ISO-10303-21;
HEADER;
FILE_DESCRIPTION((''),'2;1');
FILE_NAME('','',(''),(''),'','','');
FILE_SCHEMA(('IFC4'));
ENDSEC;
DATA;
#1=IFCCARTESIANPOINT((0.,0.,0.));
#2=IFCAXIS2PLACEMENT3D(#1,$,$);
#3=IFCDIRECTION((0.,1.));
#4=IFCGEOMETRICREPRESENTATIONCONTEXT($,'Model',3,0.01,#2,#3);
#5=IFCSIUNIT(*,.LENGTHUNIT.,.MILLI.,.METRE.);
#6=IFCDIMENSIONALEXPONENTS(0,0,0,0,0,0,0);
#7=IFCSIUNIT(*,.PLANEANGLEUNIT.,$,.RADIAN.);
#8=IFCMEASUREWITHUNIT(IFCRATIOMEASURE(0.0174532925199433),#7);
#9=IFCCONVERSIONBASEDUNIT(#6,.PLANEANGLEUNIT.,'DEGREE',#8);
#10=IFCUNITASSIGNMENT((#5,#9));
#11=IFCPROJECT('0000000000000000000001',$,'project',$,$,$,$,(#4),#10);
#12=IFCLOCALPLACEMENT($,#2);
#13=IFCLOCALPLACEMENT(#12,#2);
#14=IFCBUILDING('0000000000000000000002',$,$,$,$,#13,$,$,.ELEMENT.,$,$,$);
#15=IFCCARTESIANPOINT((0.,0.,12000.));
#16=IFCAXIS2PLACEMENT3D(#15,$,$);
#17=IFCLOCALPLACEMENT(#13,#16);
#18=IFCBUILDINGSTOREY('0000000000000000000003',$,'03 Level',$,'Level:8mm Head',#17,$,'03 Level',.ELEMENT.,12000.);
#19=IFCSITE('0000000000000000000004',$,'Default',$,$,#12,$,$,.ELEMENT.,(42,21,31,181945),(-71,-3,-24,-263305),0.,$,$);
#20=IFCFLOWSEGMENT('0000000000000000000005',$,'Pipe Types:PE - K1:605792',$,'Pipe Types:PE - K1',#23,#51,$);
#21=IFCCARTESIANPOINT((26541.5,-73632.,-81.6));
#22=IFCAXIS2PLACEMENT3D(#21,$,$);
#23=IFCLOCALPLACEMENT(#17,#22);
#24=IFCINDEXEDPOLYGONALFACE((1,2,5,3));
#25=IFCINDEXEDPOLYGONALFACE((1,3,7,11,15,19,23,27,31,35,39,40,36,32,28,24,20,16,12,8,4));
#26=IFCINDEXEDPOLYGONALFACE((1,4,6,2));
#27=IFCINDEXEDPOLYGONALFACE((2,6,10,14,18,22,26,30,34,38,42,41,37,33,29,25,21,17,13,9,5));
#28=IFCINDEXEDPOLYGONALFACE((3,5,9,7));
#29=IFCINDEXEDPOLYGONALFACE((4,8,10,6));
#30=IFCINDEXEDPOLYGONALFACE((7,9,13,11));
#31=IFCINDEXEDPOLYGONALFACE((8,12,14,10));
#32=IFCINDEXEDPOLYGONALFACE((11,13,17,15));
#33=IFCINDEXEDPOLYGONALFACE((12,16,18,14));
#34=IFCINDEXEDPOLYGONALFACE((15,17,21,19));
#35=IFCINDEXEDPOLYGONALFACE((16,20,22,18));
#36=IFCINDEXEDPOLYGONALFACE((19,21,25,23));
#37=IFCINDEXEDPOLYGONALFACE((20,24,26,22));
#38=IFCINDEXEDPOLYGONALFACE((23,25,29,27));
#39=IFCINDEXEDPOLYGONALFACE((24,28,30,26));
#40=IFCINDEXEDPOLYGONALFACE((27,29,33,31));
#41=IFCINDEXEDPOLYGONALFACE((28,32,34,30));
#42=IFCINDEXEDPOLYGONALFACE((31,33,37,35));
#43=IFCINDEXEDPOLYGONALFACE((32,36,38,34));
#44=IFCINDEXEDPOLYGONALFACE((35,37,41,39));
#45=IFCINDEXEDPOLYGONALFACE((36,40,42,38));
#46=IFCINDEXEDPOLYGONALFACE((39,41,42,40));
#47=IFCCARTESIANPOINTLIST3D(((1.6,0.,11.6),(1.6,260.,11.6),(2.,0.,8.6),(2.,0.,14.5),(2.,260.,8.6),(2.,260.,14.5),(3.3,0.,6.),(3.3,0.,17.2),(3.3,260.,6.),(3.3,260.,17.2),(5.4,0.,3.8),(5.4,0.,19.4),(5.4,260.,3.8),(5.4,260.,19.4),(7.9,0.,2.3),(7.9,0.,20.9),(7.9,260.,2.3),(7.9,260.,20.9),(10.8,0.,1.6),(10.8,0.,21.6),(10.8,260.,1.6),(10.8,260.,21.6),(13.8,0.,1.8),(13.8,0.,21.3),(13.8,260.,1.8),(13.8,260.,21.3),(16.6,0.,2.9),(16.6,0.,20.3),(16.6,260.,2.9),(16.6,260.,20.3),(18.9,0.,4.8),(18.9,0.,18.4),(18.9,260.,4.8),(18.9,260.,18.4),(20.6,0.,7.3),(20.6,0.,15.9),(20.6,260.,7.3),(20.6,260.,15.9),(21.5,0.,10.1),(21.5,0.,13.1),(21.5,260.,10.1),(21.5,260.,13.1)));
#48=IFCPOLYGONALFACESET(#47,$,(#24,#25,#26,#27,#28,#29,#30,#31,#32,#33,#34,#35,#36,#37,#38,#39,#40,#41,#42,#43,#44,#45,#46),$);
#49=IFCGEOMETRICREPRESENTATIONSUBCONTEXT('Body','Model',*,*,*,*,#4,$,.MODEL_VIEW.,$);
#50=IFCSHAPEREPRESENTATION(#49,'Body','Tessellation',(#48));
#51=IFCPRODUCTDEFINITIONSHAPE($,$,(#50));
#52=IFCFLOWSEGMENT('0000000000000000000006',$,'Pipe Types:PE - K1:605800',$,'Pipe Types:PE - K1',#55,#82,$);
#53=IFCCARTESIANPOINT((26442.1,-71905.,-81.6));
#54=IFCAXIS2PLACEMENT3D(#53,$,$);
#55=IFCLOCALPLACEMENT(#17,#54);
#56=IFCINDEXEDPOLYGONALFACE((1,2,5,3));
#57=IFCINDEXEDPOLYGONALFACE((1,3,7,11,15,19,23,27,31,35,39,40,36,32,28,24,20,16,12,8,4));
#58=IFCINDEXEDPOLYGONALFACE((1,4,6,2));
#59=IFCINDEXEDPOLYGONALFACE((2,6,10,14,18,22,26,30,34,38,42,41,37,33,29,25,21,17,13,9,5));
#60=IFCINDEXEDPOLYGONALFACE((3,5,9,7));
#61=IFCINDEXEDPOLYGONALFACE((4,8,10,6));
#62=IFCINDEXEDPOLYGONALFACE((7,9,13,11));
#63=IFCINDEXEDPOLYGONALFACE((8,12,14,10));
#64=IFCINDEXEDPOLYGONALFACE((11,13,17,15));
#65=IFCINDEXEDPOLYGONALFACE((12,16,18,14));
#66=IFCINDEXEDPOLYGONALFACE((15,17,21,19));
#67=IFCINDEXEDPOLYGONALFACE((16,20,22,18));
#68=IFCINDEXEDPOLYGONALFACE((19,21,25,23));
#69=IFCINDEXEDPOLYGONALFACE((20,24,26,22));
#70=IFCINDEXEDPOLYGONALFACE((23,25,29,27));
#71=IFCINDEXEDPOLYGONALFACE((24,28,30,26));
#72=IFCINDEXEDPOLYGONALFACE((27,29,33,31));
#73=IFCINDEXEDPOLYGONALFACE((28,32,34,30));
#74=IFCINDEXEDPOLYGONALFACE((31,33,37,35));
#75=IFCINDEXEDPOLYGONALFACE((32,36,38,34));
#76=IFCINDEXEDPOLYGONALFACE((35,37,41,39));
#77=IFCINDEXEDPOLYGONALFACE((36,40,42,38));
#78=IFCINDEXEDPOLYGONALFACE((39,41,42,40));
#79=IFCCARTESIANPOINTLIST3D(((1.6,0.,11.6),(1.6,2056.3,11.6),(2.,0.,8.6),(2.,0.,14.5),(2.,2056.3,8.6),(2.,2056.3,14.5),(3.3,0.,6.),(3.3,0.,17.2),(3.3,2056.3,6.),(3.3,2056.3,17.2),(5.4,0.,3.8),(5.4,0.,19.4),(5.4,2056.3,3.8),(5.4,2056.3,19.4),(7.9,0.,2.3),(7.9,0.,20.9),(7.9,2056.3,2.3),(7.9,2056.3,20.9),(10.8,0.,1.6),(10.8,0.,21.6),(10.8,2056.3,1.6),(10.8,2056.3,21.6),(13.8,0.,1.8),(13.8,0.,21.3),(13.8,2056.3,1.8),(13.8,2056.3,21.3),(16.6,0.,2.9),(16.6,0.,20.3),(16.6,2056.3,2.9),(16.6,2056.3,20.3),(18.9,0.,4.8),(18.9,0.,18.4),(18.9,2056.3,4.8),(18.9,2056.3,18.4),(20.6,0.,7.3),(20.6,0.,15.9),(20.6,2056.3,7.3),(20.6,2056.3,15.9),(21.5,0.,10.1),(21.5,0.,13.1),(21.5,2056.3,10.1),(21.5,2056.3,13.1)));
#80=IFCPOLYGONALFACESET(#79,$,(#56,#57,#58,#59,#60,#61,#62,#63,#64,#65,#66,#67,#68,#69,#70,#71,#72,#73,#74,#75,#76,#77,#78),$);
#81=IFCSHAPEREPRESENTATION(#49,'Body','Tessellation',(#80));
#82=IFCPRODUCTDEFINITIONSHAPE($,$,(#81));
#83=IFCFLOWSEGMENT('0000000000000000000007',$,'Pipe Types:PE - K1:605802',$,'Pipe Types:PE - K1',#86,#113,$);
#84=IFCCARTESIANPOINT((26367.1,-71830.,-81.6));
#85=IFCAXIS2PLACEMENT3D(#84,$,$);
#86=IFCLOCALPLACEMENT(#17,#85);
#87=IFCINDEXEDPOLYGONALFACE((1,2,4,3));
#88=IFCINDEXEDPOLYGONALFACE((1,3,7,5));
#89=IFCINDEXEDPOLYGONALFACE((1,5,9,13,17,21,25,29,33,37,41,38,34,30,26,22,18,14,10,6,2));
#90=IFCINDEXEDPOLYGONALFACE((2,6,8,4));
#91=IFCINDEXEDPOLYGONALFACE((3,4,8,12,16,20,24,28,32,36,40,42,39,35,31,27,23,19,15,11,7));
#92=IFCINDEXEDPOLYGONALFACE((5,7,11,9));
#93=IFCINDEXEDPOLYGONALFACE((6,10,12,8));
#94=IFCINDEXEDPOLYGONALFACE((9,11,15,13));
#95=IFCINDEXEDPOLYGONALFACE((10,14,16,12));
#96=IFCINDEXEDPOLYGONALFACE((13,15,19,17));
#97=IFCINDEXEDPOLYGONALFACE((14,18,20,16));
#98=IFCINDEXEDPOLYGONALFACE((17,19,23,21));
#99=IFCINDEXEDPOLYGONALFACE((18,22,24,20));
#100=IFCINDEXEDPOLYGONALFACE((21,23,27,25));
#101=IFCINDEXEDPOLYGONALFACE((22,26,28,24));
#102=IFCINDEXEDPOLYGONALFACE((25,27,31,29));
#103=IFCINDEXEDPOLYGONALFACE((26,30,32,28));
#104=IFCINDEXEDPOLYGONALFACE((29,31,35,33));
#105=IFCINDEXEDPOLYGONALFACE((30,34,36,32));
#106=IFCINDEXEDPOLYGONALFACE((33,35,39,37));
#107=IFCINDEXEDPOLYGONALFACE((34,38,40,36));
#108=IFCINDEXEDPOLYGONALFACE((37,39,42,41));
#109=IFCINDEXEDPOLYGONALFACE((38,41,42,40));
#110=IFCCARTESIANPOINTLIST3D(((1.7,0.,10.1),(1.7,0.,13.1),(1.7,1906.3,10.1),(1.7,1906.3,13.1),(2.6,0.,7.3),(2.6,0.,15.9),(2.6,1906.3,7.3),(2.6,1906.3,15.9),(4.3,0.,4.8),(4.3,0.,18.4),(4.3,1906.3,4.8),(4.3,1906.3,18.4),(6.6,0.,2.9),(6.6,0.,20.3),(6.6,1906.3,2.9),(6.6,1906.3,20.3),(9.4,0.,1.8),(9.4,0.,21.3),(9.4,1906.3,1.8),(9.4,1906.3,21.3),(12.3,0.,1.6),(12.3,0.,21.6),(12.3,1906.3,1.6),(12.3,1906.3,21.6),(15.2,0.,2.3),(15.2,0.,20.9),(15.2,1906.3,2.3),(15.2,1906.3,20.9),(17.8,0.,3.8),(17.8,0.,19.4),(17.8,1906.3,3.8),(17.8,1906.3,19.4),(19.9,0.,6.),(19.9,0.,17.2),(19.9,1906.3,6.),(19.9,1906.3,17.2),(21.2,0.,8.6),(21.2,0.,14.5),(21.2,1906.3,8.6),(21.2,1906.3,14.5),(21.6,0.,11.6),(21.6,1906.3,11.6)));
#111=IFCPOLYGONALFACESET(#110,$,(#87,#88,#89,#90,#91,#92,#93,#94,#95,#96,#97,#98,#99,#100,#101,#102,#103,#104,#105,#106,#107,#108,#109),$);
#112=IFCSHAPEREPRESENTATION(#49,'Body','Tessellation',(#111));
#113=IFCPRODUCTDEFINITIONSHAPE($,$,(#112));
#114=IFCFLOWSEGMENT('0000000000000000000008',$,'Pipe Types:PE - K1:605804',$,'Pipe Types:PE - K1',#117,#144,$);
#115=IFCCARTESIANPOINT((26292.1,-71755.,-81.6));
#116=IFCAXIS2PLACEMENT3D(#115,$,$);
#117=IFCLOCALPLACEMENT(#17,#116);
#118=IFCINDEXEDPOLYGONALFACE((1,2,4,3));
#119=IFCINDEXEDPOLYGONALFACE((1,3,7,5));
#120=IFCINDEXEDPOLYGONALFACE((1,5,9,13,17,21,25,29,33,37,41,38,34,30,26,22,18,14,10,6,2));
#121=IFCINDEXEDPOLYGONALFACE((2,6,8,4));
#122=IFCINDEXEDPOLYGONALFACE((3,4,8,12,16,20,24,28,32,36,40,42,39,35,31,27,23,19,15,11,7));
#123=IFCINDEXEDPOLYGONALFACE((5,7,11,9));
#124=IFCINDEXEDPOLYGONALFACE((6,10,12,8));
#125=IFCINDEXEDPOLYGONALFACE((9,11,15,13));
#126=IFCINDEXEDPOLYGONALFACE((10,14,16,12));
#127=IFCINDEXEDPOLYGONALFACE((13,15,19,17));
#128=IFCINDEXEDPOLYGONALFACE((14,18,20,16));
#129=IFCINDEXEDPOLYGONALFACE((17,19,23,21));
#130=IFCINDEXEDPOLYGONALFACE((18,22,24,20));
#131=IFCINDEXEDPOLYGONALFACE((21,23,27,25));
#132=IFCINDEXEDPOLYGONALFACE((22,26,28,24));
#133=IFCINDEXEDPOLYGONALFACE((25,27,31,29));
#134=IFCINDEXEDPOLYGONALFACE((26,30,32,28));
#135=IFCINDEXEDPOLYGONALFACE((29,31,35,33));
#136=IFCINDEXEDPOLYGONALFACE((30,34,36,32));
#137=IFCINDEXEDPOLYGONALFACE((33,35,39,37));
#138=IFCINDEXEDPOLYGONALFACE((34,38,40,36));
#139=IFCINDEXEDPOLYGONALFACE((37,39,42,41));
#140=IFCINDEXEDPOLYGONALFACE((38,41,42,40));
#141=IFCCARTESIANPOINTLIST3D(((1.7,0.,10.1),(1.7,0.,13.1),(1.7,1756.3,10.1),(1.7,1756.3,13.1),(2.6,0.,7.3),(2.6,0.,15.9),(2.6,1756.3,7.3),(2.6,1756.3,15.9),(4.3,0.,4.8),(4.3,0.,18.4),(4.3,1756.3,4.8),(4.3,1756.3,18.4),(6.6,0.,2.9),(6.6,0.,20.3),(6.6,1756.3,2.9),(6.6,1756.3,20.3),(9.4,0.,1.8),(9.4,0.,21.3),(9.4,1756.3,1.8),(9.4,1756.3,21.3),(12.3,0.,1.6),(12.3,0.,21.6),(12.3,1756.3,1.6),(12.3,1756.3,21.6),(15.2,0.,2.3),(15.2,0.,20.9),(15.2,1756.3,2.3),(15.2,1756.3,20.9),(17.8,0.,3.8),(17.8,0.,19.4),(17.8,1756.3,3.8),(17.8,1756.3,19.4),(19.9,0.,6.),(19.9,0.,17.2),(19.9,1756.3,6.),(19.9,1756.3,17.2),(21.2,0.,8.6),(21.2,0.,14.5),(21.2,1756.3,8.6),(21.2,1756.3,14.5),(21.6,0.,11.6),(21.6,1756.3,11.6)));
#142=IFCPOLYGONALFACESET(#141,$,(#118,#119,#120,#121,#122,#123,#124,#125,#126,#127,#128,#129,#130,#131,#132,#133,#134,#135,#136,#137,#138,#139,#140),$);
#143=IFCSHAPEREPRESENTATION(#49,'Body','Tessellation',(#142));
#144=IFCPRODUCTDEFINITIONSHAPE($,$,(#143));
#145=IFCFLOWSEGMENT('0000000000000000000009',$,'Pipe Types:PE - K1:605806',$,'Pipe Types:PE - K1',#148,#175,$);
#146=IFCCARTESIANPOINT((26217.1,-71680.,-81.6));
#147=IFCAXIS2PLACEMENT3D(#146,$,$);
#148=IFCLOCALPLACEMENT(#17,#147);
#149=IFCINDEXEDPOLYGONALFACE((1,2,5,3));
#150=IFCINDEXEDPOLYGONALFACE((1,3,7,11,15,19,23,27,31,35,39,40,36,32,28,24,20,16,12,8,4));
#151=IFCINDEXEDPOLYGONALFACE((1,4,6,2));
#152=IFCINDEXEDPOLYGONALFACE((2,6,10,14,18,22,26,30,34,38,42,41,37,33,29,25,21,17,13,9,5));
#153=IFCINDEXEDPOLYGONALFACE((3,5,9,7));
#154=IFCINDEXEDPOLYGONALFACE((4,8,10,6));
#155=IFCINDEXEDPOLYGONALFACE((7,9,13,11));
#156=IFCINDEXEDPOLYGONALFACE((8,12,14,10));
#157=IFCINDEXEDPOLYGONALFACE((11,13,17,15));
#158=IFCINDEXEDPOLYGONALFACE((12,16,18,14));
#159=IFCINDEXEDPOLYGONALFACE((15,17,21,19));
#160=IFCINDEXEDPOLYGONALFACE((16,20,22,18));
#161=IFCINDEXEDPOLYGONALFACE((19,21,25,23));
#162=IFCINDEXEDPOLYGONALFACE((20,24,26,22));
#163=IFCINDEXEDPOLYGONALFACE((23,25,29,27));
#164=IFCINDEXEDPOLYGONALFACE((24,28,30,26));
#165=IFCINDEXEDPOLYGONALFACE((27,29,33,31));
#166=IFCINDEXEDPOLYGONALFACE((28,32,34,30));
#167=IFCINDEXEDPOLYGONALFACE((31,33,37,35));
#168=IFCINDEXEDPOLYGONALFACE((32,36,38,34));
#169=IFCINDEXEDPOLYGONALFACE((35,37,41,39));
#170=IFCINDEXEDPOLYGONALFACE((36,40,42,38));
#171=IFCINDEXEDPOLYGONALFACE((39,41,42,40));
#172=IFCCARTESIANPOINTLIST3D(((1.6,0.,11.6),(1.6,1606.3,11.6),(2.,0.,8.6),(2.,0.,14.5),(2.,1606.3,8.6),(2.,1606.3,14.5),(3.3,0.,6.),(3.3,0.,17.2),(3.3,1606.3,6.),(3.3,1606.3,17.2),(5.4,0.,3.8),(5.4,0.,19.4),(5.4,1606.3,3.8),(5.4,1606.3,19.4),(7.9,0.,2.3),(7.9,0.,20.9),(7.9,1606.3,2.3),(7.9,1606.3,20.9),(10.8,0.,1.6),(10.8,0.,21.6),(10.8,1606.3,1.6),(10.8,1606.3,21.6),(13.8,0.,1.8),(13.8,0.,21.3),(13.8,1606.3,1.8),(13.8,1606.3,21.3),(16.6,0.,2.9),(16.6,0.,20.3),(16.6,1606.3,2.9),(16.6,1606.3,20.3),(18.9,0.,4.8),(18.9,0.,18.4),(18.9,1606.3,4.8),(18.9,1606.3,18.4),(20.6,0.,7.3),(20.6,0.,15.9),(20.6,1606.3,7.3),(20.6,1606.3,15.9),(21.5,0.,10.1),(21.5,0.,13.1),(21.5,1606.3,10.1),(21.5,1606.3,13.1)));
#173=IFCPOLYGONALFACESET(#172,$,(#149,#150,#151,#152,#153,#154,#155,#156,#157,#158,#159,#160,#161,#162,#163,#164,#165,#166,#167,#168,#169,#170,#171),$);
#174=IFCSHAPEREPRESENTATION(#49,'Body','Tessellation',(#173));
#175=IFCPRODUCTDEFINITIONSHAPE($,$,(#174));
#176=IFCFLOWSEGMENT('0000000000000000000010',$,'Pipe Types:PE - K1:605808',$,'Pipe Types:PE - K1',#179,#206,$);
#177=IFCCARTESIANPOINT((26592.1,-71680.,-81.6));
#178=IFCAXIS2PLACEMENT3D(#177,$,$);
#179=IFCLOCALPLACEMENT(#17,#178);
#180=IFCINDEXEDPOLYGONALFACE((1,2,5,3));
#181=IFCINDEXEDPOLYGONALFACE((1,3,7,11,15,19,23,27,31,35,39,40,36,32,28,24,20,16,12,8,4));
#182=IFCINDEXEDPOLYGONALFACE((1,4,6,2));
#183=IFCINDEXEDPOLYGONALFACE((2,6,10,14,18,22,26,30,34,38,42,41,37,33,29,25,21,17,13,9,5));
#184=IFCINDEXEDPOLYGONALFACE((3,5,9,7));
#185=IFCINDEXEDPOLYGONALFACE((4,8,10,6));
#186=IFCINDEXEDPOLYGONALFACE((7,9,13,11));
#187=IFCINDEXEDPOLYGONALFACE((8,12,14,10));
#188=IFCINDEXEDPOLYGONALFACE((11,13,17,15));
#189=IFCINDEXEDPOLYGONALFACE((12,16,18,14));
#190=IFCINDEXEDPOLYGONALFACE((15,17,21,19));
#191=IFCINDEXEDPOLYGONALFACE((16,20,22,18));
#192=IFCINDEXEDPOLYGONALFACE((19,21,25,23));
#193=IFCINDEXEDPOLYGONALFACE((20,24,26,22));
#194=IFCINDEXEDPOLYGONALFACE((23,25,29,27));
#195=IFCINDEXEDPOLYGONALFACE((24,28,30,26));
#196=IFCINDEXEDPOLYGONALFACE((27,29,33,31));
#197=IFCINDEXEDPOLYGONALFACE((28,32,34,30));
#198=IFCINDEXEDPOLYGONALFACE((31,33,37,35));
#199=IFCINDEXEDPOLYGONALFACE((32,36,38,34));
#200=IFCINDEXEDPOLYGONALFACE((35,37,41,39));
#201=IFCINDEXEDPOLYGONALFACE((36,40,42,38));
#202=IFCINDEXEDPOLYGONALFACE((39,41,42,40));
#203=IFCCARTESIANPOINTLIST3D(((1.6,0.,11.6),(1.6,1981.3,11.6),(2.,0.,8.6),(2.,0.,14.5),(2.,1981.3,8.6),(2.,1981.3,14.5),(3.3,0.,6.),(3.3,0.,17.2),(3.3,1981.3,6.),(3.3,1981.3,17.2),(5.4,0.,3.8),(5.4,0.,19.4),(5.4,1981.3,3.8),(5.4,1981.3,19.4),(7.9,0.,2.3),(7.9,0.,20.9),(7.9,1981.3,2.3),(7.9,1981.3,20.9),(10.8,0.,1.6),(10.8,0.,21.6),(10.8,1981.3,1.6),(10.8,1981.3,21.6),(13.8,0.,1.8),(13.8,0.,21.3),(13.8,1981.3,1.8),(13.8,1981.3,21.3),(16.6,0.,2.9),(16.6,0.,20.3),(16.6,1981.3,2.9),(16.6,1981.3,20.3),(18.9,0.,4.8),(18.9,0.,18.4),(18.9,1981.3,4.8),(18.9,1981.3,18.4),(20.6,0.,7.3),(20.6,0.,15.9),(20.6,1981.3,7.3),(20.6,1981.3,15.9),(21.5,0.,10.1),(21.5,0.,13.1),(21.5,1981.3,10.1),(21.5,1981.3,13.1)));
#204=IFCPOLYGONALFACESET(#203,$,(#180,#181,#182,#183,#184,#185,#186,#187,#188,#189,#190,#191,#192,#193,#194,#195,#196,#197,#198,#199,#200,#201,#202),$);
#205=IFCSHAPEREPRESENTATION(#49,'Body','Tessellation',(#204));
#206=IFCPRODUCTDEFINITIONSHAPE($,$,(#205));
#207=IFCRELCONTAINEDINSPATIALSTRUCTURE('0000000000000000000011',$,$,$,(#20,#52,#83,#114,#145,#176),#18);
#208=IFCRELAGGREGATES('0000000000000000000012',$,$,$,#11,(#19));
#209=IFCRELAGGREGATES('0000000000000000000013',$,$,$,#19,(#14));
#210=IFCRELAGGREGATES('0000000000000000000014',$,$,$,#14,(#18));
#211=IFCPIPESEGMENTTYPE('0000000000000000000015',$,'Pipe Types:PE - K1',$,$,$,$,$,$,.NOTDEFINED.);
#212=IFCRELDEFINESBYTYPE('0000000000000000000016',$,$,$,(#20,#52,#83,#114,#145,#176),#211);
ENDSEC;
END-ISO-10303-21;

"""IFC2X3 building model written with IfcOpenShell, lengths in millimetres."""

from ifc_helpers import new_model, entity, si_unit, converted_unit, direction, frame, frame_2d, origin, origin_2d_with_axis, place, context, subcontext, project, spatial, circle, extrude, type_object, element, save


model = new_model("IFC2X3")

# Units and contexts
model_context = context("Model", 3, precision=0.01, world=origin(), true_north=direction((0.0, 1.0)))
body_context = subcontext(model_context, "Body", "Model", "MODEL_VIEW")
ifc_project = project(units=[si_unit("LENGTHUNIT", "METRE", prefix="MILLI"), converted_unit("PLANEANGLEUNIT", "DEGREE", entity("IfcRatioMeasure", 0.0174532925199433), si_unit("PLANEANGLEUNIT", "RADIAN"), dimensions=[0, 0, 0, 0, 0, 0, 0])], contexts=[model_context])

# Site, building, storey
site_placement = place(None, origin())
site = spatial("IfcSite", under=ifc_project, at=site_placement, Name="Default", CompositionType="ELEMENT", RefLatitude=(42, 21, 31, 181945), RefLongitude=(-71, -3, -24, -263305), RefElevation=0.0)
building_placement = place(site_placement, origin())
building = spatial("IfcBuilding", under=site, at=building_placement, CompositionType="ELEMENT")
storey_placement = place(building_placement, frame((0.0, 0.0, 12000.0)))
storey = spatial("IfcBuildingStorey", under=building, at=storey_placement, Name="03 Level", ObjectType="Level:8mm Head", LongName="03 Level", CompositionType="ELEMENT", Elevation=12000.0)

# Flow segments
pipe_segment_type = type_object("IfcPipeSegmentType", Name="Pipe Types:PE - K1", PredefinedType="NOTDEFINED")
flow_segment_1_placement = place(storey_placement, frame((26541.5, -73632.0, -81.6)))
element("IfcFlowSegment", 1, at=flow_segment_1_placement, inside=storey, type_object=pipe_segment_type, Name="Pipe Types:PE - K1:605792", ObjectType="Pipe Types:PE - K1", context=body_context, shape_type="SweptSolid", body=[
    extrude(circle(Radius=10.0, at=frame_2d((0.0, 0.0), x_axis=(1.0, 0.0))), frame((11.6, 0.0, 11.6), z_axis=(0.0, 1.0, 0.0), x_axis=(-1.0, 0.0, 0.0)), (0.0, 0.0, 1.0), 260.0),
])
flow_segment_2_placement = place(storey_placement, frame((26442.1, -71905.0, -81.6)))
element("IfcFlowSegment", 2, at=flow_segment_2_placement, inside=storey, type_object=pipe_segment_type, Name="Pipe Types:PE - K1:605800", ObjectType="Pipe Types:PE - K1", context=body_context, shape_type="SweptSolid", body=[
    extrude(circle(Radius=10.0, at=origin_2d_with_axis()), frame((11.6, 0.0, 11.6), z_axis=(0.0, 1.0, 0.0), x_axis=(-1.0, 0.0, 0.0)), (0.0, 0.0, 1.0), 2056.3),
])
flow_segment_3_placement = place(storey_placement, frame((26367.1, -71830.0, -81.6)))
element("IfcFlowSegment", 3, at=flow_segment_3_placement, inside=storey, type_object=pipe_segment_type, Name="Pipe Types:PE - K1:605802", ObjectType="Pipe Types:PE - K1", context=body_context, shape_type="SweptSolid", body=[
    extrude(circle(Radius=10.0, at=origin_2d_with_axis()), frame((11.6, 0.0, 11.6), z_axis=(0.0, 1.0, 0.0), x_axis=(1.0, 0.0, 0.0)), (0.0, 0.0, 1.0), 1906.3),
])
flow_segment_4_placement = place(storey_placement, frame((26292.1, -71755.0, -81.6)))
element("IfcFlowSegment", 4, at=flow_segment_4_placement, inside=storey, type_object=pipe_segment_type, Name="Pipe Types:PE - K1:605804", ObjectType="Pipe Types:PE - K1", context=body_context, shape_type="SweptSolid", body=[
    extrude(circle(Radius=10.0, at=origin_2d_with_axis()), frame((11.6, 0.0, 11.6), z_axis=(0.0, 1.0, 0.0), x_axis=(1.0, 0.0, 0.0)), (0.0, 0.0, 1.0), 1756.3),
])
flow_segment_5_placement = place(storey_placement, frame((26217.1, -71680.0, -81.6)))
element("IfcFlowSegment", 5, at=flow_segment_5_placement, inside=storey, type_object=pipe_segment_type, Name="Pipe Types:PE - K1:605806", ObjectType="Pipe Types:PE - K1", context=body_context, shape_type="SweptSolid", body=[
    extrude(circle(Radius=10.0, at=frame_2d((0.0, 0.0), x_axis=(1.0, 0.0))), frame((11.6, 0.0, 11.6), z_axis=(0.0, 1.0, 0.0), x_axis=(-1.0, 0.0, 0.0)), (0.0, 0.0, 1.0), 1606.3),
])
flow_segment_6_placement = place(storey_placement, frame((26592.1, -71680.0, -81.6)))
element("IfcFlowSegment", 6, at=flow_segment_6_placement, inside=storey, type_object=pipe_segment_type, Name="Pipe Types:PE - K1:605808", ObjectType="Pipe Types:PE - K1", context=body_context, shape_type="SweptSolid", body=[
    extrude(circle(Radius=10.0, at=frame_2d((0.0, 0.0), x_axis=(1.0, 0.0))), frame((11.6, 0.0, 11.6), z_axis=(0.0, 1.0, 0.0), x_axis=(-1.0, 0.0, 0.0)), (0.0, 0.0, 1.0), 1981.3),
])

save(model, "model.ifc")
